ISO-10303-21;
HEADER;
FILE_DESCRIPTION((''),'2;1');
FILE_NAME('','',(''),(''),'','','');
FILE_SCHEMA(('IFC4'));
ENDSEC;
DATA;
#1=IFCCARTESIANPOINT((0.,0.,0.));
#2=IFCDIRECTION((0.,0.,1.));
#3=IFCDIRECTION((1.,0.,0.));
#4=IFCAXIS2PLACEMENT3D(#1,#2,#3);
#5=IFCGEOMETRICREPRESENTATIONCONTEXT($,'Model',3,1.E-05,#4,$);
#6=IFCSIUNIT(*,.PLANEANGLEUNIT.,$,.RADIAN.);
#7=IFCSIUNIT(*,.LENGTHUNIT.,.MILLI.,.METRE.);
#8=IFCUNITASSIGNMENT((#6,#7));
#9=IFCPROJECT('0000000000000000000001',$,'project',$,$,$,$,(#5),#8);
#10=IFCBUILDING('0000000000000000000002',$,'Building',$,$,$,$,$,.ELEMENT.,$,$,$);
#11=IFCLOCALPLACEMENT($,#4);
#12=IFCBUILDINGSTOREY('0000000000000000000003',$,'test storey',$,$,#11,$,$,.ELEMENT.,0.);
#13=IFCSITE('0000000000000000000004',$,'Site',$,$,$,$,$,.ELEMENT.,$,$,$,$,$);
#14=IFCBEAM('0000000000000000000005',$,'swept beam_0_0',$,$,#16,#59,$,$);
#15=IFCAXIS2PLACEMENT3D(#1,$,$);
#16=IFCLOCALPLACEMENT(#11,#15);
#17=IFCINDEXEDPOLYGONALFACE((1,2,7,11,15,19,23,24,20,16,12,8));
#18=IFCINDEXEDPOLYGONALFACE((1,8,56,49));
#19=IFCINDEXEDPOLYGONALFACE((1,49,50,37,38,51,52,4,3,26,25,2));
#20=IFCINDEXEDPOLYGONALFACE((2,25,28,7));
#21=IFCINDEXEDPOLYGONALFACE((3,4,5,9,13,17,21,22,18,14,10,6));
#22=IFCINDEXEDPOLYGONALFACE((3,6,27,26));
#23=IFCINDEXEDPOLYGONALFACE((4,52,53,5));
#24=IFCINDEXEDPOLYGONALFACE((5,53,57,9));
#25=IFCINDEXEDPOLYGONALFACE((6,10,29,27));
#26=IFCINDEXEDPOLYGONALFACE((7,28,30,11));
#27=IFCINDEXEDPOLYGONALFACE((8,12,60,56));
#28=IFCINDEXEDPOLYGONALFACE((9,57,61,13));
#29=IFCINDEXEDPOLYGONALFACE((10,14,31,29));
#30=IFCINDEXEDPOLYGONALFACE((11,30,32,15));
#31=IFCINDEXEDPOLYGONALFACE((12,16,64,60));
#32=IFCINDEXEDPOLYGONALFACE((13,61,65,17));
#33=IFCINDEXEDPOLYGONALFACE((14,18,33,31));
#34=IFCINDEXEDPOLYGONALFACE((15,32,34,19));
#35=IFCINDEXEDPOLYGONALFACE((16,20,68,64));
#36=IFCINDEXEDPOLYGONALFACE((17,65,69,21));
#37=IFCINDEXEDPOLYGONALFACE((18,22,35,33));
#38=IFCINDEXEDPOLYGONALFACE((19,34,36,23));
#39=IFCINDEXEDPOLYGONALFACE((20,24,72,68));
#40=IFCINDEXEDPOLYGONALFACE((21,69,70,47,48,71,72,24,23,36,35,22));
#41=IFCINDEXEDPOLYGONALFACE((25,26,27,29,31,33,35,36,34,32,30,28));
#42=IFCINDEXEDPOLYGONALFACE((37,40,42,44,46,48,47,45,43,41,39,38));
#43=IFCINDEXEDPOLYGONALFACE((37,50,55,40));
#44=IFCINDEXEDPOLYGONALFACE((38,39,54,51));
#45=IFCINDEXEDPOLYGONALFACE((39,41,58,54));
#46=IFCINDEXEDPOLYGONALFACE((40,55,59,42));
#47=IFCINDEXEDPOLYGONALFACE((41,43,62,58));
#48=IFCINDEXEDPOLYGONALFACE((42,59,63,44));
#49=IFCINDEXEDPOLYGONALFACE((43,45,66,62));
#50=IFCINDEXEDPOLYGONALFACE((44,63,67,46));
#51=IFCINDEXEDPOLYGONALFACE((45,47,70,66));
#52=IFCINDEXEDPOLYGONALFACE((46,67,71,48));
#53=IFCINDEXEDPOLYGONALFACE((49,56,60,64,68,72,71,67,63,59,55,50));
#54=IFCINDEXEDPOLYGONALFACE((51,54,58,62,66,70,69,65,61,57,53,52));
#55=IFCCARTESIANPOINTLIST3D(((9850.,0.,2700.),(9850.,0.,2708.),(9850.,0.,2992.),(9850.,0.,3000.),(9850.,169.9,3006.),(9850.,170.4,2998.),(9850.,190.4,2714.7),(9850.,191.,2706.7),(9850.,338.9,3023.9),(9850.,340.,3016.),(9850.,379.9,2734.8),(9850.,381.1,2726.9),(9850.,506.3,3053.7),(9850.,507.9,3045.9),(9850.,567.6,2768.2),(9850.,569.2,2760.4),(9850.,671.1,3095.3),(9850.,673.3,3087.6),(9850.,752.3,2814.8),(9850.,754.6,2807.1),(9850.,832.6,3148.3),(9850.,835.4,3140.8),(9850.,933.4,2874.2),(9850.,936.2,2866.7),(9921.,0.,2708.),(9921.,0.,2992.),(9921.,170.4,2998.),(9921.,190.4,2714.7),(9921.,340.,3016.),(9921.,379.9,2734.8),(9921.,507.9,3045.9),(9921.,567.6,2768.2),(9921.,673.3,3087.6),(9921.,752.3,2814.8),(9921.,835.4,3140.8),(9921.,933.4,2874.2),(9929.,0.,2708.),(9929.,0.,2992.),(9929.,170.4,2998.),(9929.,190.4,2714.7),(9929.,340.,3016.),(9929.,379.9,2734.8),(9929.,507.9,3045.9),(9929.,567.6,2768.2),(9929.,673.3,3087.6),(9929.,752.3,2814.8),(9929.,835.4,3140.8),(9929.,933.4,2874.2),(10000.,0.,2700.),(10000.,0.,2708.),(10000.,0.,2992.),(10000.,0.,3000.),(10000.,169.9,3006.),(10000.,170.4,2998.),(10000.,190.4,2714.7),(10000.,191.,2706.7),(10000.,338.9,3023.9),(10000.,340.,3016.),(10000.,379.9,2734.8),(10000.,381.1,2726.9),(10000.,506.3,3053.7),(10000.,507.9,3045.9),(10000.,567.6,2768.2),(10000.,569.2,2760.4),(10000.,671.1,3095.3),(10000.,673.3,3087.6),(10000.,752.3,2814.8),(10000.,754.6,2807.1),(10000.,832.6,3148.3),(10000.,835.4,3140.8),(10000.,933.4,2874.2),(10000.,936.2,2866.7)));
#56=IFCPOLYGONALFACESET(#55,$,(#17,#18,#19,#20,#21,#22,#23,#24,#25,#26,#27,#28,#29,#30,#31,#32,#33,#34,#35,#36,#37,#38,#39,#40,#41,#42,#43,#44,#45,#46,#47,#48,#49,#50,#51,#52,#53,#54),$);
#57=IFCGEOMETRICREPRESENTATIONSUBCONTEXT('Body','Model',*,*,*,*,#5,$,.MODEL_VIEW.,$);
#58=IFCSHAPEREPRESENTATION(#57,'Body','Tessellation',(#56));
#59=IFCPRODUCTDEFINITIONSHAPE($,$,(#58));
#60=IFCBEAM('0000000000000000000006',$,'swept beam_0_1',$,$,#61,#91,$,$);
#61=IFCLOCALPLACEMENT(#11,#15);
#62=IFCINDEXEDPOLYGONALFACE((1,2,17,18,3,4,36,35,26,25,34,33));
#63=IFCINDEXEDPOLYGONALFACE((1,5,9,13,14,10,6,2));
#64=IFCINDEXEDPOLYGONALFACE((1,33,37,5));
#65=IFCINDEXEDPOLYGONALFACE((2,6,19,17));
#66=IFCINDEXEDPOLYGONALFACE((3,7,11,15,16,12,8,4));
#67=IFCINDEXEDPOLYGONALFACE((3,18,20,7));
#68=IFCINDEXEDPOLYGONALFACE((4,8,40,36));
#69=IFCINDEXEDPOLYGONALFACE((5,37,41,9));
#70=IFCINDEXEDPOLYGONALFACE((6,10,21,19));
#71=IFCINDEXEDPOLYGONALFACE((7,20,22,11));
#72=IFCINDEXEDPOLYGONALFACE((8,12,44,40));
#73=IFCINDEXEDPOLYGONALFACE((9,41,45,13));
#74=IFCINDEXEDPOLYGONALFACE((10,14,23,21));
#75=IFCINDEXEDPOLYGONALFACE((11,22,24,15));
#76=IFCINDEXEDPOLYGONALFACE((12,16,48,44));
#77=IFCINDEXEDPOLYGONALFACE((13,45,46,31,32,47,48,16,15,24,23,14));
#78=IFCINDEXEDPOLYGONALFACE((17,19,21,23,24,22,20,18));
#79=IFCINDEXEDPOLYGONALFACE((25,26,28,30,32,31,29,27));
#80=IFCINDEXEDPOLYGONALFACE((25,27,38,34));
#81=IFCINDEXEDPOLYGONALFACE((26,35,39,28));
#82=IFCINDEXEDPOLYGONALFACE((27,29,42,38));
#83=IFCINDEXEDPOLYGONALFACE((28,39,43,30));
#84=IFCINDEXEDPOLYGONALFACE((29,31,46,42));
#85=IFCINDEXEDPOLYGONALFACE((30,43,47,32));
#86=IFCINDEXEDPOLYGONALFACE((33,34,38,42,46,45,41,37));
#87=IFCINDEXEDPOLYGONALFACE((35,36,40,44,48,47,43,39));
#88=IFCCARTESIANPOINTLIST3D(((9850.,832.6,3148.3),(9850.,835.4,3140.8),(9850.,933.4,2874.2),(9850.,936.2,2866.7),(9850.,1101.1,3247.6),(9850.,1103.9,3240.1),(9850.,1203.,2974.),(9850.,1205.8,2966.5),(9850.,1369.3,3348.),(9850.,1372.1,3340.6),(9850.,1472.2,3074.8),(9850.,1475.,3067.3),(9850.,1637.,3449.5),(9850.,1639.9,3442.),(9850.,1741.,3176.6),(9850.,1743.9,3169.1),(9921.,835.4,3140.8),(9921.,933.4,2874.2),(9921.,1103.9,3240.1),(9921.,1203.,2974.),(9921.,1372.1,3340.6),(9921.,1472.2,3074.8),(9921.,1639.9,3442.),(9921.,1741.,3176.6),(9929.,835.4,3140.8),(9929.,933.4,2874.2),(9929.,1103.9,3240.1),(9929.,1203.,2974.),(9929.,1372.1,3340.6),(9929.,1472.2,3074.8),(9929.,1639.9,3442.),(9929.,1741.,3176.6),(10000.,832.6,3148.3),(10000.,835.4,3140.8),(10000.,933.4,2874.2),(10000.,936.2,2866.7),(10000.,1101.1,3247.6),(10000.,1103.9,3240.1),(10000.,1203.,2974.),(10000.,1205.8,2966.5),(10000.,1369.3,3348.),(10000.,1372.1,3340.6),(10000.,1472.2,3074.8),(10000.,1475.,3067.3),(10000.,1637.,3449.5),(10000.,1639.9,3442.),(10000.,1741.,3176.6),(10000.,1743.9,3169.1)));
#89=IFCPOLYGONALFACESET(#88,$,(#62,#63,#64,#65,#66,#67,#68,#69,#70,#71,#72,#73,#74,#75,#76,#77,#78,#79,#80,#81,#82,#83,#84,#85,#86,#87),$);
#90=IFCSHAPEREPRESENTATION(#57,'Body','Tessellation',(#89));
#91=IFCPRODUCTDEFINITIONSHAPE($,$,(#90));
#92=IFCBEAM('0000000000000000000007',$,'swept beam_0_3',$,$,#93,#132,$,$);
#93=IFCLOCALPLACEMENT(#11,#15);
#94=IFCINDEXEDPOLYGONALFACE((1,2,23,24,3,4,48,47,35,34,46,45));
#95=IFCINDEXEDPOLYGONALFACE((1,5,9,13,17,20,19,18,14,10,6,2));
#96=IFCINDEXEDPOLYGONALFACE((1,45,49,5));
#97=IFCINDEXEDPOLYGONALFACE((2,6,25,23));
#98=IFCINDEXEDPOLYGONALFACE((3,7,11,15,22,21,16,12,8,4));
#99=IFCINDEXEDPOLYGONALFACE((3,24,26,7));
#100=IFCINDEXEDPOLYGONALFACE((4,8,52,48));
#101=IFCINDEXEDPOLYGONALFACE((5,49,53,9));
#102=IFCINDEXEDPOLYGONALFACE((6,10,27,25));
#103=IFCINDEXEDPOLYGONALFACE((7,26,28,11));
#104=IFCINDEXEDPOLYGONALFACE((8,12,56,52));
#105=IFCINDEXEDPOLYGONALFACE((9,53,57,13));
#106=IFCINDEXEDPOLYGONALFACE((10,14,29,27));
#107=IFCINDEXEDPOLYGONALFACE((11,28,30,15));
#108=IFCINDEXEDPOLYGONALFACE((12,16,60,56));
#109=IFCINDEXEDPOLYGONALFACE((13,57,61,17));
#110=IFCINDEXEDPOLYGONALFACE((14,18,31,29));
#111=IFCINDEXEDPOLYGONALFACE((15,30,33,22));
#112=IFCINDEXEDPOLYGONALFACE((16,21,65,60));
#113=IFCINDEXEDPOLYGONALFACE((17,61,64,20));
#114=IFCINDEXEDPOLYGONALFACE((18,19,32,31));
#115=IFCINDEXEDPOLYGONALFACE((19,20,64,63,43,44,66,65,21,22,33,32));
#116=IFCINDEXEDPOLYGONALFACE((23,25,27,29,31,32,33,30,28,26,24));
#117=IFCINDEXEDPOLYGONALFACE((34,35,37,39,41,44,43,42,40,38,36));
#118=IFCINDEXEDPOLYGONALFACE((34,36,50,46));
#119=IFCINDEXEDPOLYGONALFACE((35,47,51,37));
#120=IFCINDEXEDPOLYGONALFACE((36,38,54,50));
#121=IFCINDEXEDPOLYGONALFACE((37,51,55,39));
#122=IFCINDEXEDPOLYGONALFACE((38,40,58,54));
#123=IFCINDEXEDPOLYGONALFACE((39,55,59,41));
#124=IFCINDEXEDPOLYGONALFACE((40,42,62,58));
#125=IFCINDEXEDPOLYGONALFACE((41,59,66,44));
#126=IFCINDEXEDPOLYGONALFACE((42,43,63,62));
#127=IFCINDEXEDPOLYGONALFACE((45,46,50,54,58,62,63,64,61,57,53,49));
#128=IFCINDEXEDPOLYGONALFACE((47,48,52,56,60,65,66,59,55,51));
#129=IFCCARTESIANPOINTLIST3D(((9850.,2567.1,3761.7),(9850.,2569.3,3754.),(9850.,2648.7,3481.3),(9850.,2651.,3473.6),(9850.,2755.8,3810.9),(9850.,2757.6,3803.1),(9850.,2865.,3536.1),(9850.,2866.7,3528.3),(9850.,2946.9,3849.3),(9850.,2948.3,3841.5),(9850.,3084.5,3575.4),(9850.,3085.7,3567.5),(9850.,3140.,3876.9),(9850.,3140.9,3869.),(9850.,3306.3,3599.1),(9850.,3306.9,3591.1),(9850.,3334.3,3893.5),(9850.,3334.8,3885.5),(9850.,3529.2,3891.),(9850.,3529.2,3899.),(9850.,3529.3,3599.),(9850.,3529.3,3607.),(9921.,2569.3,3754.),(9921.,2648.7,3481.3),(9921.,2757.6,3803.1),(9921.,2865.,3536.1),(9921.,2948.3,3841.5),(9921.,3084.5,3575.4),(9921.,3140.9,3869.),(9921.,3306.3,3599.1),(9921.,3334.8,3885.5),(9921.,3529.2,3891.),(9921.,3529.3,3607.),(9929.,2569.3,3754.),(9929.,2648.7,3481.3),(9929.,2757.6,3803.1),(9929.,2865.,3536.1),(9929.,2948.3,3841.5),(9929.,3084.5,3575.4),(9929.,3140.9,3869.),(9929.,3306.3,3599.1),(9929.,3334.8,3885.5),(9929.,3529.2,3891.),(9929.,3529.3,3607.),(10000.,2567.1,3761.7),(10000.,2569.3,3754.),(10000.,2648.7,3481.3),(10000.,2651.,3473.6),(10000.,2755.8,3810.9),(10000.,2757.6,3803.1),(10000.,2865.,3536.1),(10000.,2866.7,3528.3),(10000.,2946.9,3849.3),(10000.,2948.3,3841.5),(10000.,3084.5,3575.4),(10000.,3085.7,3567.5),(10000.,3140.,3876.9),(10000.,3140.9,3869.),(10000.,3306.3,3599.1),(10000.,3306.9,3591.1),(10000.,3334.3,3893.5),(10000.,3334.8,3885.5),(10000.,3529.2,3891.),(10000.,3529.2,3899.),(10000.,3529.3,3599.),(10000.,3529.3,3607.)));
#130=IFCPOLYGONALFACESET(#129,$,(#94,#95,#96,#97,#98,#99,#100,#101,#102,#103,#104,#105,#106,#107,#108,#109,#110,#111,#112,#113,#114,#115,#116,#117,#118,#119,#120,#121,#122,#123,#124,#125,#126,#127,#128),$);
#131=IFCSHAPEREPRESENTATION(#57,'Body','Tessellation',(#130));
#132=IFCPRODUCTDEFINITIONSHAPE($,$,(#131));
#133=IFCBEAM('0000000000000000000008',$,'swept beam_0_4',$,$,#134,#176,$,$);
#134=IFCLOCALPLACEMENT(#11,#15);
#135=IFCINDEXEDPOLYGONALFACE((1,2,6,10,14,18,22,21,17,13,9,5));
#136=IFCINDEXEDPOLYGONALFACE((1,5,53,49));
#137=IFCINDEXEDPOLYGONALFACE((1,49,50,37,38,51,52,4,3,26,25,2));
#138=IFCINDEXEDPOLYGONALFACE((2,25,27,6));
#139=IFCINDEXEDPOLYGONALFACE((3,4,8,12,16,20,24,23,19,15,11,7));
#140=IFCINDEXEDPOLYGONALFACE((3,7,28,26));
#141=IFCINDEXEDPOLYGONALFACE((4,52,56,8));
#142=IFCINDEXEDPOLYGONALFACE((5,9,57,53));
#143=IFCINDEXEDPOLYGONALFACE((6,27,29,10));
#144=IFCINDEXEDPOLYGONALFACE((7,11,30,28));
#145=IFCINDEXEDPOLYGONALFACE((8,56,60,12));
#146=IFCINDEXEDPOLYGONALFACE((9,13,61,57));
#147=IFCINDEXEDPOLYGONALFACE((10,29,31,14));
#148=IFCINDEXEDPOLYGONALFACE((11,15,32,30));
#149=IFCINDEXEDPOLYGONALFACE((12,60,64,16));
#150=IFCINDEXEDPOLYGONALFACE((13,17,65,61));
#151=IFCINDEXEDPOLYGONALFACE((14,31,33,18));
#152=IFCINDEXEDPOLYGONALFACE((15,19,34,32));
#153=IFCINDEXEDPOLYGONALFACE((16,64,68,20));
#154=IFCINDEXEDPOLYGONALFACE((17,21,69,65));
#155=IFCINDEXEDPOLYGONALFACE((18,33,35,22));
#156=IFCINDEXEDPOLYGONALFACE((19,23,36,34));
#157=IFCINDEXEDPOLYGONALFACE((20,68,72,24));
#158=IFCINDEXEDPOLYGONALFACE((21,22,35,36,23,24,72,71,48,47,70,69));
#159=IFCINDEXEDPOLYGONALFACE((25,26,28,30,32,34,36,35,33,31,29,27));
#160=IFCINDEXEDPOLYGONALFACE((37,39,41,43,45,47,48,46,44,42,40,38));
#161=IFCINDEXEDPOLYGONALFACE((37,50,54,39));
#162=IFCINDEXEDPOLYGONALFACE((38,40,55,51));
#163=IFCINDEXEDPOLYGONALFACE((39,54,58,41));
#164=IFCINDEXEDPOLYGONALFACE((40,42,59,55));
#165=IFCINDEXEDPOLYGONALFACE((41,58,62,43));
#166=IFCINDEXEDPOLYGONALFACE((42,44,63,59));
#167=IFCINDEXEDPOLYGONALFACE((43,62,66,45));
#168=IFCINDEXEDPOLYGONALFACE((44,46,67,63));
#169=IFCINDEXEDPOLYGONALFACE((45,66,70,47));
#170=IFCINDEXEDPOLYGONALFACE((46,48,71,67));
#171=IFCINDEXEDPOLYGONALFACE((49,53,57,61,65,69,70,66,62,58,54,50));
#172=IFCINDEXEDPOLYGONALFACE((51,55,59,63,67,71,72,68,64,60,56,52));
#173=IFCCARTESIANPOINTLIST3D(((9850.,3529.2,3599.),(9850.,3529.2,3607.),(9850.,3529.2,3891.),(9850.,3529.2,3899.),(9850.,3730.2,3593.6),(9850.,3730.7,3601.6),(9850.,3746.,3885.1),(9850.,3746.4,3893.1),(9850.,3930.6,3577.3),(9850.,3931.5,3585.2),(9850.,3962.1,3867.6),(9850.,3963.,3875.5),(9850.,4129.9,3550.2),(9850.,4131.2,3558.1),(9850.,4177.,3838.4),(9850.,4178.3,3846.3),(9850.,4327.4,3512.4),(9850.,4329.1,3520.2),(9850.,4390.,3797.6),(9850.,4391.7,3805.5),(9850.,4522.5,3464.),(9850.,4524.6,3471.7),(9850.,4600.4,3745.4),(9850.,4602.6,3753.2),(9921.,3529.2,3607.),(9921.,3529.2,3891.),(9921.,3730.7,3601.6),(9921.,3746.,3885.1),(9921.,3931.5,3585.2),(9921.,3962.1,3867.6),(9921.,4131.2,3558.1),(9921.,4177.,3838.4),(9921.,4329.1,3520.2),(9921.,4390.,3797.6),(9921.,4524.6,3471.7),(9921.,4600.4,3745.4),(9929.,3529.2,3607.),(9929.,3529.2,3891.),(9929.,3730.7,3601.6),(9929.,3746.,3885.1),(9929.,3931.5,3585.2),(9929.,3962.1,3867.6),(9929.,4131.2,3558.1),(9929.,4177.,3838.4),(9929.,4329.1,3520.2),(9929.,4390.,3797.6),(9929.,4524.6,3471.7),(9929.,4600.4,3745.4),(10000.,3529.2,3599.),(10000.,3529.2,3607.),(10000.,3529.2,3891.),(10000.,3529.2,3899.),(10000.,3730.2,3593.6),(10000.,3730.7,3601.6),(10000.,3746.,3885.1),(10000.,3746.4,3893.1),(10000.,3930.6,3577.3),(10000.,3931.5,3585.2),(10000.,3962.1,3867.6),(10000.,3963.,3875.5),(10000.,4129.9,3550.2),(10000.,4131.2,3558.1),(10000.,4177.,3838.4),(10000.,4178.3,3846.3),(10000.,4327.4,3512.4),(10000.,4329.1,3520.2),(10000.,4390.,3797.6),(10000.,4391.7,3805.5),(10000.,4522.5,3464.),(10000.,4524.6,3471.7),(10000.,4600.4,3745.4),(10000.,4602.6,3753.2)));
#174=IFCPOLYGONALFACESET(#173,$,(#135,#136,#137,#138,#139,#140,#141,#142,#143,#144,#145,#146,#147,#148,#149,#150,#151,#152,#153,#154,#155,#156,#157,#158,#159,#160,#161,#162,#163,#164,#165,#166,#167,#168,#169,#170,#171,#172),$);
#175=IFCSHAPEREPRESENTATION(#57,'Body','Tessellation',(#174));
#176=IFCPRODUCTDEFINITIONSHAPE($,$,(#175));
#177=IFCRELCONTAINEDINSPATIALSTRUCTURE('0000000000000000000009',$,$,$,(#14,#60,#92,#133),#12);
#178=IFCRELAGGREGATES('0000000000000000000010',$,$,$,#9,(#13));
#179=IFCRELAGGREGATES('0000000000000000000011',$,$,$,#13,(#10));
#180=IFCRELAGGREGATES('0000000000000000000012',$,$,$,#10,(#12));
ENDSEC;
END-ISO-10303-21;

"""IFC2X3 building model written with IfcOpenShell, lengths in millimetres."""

from ifc_helpers import new_model, entity, si_unit, origin_with_axes, place, context, subcontext, project, spatial, element, save


model = new_model("IFC2X3")

# Units and contexts
model_context = context("Model", 3, precision=1e-05, world=origin_with_axes())
body_context = subcontext(model_context, "Body", "Model", "MODEL_VIEW")
ifc_project = project(units=[si_unit("PLANEANGLEUNIT", "RADIAN"), si_unit("LENGTHUNIT", "METRE", prefix="MILLI")], contexts=[model_context])

# Site, building, storey
site = spatial("IfcSite", under=ifc_project, Name="Site", CompositionType="ELEMENT")
building = spatial("IfcBuilding", under=site, Name="Building", CompositionType="ELEMENT")
storey_placement = place(None, origin_with_axes())
storey = spatial("IfcBuildingStorey", under=building, at=storey_placement, Name="test storey", CompositionType="ELEMENT", Elevation=0.0)

# Beams
beam_1_placement = place(storey_placement, origin_with_axes())
element("IfcBeam", 1, at=beam_1_placement, inside=storey, Name="swept beam_0_0", context=body_context, shape_type="SweptSolid", body=[
    entity("IfcRevolvedAreaSolid", entity("IfcArbitraryClosedProfileDef", "AREA", None, entity("IfcPolyline", [entity("IfcCartesianPoint", [292.0, 0.0]), entity("IfcCartesianPoint", [292.0, -71.0]), entity("IfcCartesianPoint", [8.0, -71.0]), entity("IfcCartesianPoint", [8.0, 0.0]), entity("IfcCartesianPoint", [0.0, 0.0]), entity("IfcCartesianPoint", [0.0, -150.0]), entity("IfcCartesianPoint", [8.0, -150.0]), entity("IfcCartesianPoint", [8.0, -79.0]), entity("IfcCartesianPoint", [292.0, -79.0]), entity("IfcCartesianPoint", [292.0, -150.0]), entity("IfcCartesianPoint", [300.0, -150.0]), entity("IfcCartesianPoint", [300.0, 0.0]), entity("IfcCartesianPoint", [292.0, 0.0])])), entity("IfcAxis2Placement3D", entity("IfcCartesianPoint", [10000.0, 0.0, 3000.0]), entity("IfcDirection", [0.0, -1.0, 0.0]), entity("IfcDirection", [0.0, 0.0, -1.0])), entity("IfcAxis1Placement", entity("IfcCartesianPoint", [-2411.7, 0.0, 0.0]), entity("IfcDirection", [0.0, 1.0, 0.0])), 0.35249),
])
beam_2_placement = place(storey_placement, origin_with_axes())
element("IfcBeam", 2, at=beam_2_placement, inside=storey, Name="swept beam_0_1", context=body_context, shape_type="SweptSolid", body=[
    entity("IfcRevolvedAreaSolid", entity("IfcArbitraryClosedProfileDef", "AREA", None, entity("IfcPolyline", [entity("IfcCartesianPoint", [292.0, 0.0]), entity("IfcCartesianPoint", [292.0, -71.0]), entity("IfcCartesianPoint", [8.0, -71.0]), entity("IfcCartesianPoint", [8.0, 0.0]), entity("IfcCartesianPoint", [0.0, 0.0]), entity("IfcCartesianPoint", [0.0, -150.0]), entity("IfcCartesianPoint", [8.0, -150.0]), entity("IfcCartesianPoint", [8.0, -79.0]), entity("IfcCartesianPoint", [292.0, -79.0]), entity("IfcCartesianPoint", [292.0, -150.0]), entity("IfcCartesianPoint", [300.0, -150.0]), entity("IfcCartesianPoint", [300.0, 0.0]), entity("IfcCartesianPoint", [292.0, 0.0])])), entity("IfcAxis2Placement3D", entity("IfcCartesianPoint", [10000.0, 832.6, 3148.3]), entity("IfcDirection", [0.0, -0.9385, -0.3452]), entity("IfcDirection", [0.0, 0.3452, -0.9385])), entity("IfcAxis1Placement", entity("IfcCartesianPoint", [-74085.4, 0.0, 0.0]), entity("IfcDirection", [0.0, 1.0, 0.0])), 0.011595),
])
beam_3_placement = place(storey_placement, origin_with_axes())
element("IfcBeam", 3, at=beam_3_placement, inside=storey, Name="swept beam_0_3", context=body_context, shape_type="SweptSolid", body=[
    entity("IfcRevolvedAreaSolid", entity("IfcArbitraryClosedProfileDef", "AREA", None, entity("IfcPolyline", [entity("IfcCartesianPoint", [-292.0, 0.0]), entity("IfcCartesianPoint", [-292.0, 71.0]), entity("IfcCartesianPoint", [-8.0, 71.0]), entity("IfcCartesianPoint", [-8.0, 0.0]), entity("IfcCartesianPoint", [0.0, 0.0]), entity("IfcCartesianPoint", [0.0, 150.0]), entity("IfcCartesianPoint", [-8.0, 150.0]), entity("IfcCartesianPoint", [-8.0, 79.0]), entity("IfcCartesianPoint", [-292.0, 79.0]), entity("IfcCartesianPoint", [-292.0, 150.0]), entity("IfcCartesianPoint", [-300.0, 150.0]), entity("IfcCartesianPoint", [-300.0, 0.0]), entity("IfcCartesianPoint", [-292.0, 0.0])])), entity("IfcAxis2Placement3D", entity("IfcCartesianPoint", [10000.0, 2567.1, 3761.7]), entity("IfcDirection", [0.0, -0.9601, -0.2798]), entity("IfcDirection", [0.0, -0.2798, 0.9601])), entity("IfcAxis1Placement", entity("IfcCartesianPoint", [-3439.1, 0.0, 0.0]), entity("IfcDirection", [0.0, 1.0, 0.0])), 0.283569),
])
beam_4_placement = place(storey_placement, origin_with_axes())
element("IfcBeam", 4, at=beam_4_placement, inside=storey, Name="swept beam_0_4", context=body_context, shape_type="SweptSolid", body=[
    entity("IfcRevolvedAreaSolid", entity("IfcArbitraryClosedProfileDef", "AREA", None, entity("IfcPolyline", [entity("IfcCartesianPoint", [-292.0, 0.0]), entity("IfcCartesianPoint", [-292.0, 71.0]), entity("IfcCartesianPoint", [-8.0, 71.0]), entity("IfcCartesianPoint", [-8.0, 0.0]), entity("IfcCartesianPoint", [0.0, 0.0]), entity("IfcCartesianPoint", [0.0, 150.0]), entity("IfcCartesianPoint", [-8.0, 150.0]), entity("IfcCartesianPoint", [-8.0, 79.0]), entity("IfcCartesianPoint", [-292.0, 79.0]), entity("IfcCartesianPoint", [-292.0, 150.0]), entity("IfcCartesianPoint", [-300.0, 150.0]), entity("IfcCartesianPoint", [-300.0, 0.0]), entity("IfcCartesianPoint", [-292.0, 0.0])])), entity("IfcAxis2Placement3D", entity("IfcCartesianPoint", [10000.0, 3529.2, 3899.0]), entity("IfcDirection", [0.0, -1.0, 0.0]), entity("IfcDirection", [0.0, 0.0, 1.0])), entity("IfcAxis1Placement", entity("IfcCartesianPoint", [-4022.2, 0.0, 0.0]), entity("IfcDirection", [0.0, 1.0, 0.0])), 0.270117),
])

save(model, "model.ifc")
